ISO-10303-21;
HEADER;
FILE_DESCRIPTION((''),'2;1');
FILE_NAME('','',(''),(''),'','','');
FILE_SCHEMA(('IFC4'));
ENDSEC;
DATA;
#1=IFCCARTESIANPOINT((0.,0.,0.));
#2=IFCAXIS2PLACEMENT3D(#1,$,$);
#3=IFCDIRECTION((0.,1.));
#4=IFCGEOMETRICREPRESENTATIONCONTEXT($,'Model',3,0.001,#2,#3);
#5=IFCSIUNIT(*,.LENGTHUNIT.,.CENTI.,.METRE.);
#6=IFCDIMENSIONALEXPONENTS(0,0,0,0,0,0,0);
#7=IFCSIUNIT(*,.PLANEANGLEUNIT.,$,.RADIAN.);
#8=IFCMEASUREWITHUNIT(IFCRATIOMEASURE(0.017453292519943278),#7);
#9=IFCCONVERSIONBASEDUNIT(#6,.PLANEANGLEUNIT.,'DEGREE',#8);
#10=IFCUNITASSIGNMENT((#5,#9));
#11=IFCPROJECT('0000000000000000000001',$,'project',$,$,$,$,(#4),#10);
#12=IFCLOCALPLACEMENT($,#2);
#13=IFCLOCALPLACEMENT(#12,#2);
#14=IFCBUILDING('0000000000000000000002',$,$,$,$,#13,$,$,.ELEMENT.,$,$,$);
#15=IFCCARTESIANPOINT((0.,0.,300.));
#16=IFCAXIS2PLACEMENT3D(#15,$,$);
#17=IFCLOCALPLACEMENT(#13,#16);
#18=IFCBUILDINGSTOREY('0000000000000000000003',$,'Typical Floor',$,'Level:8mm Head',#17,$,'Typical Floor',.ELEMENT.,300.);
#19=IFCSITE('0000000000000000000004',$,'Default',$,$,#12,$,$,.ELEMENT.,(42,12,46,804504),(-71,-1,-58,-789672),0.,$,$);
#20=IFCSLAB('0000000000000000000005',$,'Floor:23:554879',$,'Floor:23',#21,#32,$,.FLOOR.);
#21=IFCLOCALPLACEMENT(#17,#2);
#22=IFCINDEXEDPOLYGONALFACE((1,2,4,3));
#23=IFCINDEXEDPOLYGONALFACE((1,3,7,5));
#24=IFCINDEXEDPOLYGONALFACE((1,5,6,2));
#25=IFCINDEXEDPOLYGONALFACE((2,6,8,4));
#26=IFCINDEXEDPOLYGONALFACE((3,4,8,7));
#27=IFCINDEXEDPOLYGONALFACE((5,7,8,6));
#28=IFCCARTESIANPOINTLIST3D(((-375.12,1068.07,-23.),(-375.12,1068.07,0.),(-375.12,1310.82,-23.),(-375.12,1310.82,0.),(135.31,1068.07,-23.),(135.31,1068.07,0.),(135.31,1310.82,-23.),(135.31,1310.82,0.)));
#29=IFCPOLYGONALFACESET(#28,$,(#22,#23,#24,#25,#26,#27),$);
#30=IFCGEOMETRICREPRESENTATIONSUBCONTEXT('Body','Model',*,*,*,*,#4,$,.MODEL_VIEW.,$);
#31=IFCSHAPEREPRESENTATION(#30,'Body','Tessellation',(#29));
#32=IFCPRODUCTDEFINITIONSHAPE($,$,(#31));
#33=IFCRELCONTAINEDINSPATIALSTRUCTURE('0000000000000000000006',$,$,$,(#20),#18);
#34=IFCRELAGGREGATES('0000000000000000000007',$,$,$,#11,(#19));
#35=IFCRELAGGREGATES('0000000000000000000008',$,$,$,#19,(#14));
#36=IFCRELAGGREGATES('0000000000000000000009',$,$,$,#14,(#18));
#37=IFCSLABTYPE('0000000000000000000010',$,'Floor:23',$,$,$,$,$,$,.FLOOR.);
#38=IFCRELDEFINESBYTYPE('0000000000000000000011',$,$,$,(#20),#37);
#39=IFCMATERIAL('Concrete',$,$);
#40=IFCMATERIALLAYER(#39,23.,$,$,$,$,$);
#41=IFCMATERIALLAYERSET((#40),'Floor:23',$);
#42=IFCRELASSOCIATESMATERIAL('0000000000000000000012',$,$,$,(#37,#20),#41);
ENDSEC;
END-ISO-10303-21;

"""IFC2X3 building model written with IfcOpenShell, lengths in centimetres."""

from ifc_helpers import new_model, entity, si_unit, converted_unit, direction, frame, origin, origin_2d_with_axis, place, context, subcontext, project, spatial, rectangle, extrude, material, layer, layer_set, layer_usage, type_object, element, save


model = new_model("IFC2X3")

# Units and contexts
model_context = context("Model", 3, precision=0.001, world=origin(), true_north=direction((0.0, 1.0)))
body_context = subcontext(model_context, "Body", "Model", "MODEL_VIEW")
ifc_project = project(units=[si_unit("LENGTHUNIT", "METRE", prefix="CENTI"), converted_unit("PLANEANGLEUNIT", "DEGREE", entity("IfcRatioMeasure", 0.017453292519943278), si_unit("PLANEANGLEUNIT", "RADIAN"), dimensions=[0, 0, 0, 0, 0, 0, 0])], contexts=[model_context])

# Site, building, storey
site_placement = place(None, origin())
site = spatial("IfcSite", under=ifc_project, at=site_placement, Name="Default", CompositionType="ELEMENT", RefLatitude=(42, 12, 46, 804504), RefLongitude=(-71, -1, -58, -789672), RefElevation=0.0)
building_placement = place(site_placement, origin())
building = spatial("IfcBuilding", under=site, at=building_placement, CompositionType="ELEMENT")
storey_placement = place(building_placement, frame((0.0, 0.0, 300.0)))
storey = spatial("IfcBuildingStorey", under=building, at=storey_placement, Name="Typical Floor", ObjectType="Level:8mm Head", LongName="Typical Floor", CompositionType="ELEMENT", Elevation=300.0)

# Shared definitions
ifc_material = material(Name="Concrete")

# Slab
ifc_layer = layer(ifc_material, 23.0)
ifc_layer_set = layer_set([ifc_layer], Name="Floor:23")
ifc_layer_usage_1 = layer_usage(ifc_layer_set, "AXIS3", "POSITIVE", 0.0)
slab_type_1 = type_object("IfcSlabType", Name="Floor:23", PredefinedType="FLOOR", material=ifc_layer_set)
slab_1_placement = place(storey_placement, origin())
element("IfcSlab", 1, at=slab_1_placement, inside=storey, type_object=slab_type_1, material=ifc_layer_usage_1, Name="Floor:23:554879", ObjectType="Floor:23", PredefinedType="FLOOR", context=body_context, shape_type="SweptSolid", body=[
    extrude(rectangle(XDim=242.75, YDim=510.43, at=origin_2d_with_axis()), frame((-119.91, 1189.45, 0.0), z_axis=(0.0, 0.0, -1.0), x_axis=(0.0, 1.0, 0.0)), (0.0, 0.0, 1.0), 23.0),
])

save(model, "model.ifc")
